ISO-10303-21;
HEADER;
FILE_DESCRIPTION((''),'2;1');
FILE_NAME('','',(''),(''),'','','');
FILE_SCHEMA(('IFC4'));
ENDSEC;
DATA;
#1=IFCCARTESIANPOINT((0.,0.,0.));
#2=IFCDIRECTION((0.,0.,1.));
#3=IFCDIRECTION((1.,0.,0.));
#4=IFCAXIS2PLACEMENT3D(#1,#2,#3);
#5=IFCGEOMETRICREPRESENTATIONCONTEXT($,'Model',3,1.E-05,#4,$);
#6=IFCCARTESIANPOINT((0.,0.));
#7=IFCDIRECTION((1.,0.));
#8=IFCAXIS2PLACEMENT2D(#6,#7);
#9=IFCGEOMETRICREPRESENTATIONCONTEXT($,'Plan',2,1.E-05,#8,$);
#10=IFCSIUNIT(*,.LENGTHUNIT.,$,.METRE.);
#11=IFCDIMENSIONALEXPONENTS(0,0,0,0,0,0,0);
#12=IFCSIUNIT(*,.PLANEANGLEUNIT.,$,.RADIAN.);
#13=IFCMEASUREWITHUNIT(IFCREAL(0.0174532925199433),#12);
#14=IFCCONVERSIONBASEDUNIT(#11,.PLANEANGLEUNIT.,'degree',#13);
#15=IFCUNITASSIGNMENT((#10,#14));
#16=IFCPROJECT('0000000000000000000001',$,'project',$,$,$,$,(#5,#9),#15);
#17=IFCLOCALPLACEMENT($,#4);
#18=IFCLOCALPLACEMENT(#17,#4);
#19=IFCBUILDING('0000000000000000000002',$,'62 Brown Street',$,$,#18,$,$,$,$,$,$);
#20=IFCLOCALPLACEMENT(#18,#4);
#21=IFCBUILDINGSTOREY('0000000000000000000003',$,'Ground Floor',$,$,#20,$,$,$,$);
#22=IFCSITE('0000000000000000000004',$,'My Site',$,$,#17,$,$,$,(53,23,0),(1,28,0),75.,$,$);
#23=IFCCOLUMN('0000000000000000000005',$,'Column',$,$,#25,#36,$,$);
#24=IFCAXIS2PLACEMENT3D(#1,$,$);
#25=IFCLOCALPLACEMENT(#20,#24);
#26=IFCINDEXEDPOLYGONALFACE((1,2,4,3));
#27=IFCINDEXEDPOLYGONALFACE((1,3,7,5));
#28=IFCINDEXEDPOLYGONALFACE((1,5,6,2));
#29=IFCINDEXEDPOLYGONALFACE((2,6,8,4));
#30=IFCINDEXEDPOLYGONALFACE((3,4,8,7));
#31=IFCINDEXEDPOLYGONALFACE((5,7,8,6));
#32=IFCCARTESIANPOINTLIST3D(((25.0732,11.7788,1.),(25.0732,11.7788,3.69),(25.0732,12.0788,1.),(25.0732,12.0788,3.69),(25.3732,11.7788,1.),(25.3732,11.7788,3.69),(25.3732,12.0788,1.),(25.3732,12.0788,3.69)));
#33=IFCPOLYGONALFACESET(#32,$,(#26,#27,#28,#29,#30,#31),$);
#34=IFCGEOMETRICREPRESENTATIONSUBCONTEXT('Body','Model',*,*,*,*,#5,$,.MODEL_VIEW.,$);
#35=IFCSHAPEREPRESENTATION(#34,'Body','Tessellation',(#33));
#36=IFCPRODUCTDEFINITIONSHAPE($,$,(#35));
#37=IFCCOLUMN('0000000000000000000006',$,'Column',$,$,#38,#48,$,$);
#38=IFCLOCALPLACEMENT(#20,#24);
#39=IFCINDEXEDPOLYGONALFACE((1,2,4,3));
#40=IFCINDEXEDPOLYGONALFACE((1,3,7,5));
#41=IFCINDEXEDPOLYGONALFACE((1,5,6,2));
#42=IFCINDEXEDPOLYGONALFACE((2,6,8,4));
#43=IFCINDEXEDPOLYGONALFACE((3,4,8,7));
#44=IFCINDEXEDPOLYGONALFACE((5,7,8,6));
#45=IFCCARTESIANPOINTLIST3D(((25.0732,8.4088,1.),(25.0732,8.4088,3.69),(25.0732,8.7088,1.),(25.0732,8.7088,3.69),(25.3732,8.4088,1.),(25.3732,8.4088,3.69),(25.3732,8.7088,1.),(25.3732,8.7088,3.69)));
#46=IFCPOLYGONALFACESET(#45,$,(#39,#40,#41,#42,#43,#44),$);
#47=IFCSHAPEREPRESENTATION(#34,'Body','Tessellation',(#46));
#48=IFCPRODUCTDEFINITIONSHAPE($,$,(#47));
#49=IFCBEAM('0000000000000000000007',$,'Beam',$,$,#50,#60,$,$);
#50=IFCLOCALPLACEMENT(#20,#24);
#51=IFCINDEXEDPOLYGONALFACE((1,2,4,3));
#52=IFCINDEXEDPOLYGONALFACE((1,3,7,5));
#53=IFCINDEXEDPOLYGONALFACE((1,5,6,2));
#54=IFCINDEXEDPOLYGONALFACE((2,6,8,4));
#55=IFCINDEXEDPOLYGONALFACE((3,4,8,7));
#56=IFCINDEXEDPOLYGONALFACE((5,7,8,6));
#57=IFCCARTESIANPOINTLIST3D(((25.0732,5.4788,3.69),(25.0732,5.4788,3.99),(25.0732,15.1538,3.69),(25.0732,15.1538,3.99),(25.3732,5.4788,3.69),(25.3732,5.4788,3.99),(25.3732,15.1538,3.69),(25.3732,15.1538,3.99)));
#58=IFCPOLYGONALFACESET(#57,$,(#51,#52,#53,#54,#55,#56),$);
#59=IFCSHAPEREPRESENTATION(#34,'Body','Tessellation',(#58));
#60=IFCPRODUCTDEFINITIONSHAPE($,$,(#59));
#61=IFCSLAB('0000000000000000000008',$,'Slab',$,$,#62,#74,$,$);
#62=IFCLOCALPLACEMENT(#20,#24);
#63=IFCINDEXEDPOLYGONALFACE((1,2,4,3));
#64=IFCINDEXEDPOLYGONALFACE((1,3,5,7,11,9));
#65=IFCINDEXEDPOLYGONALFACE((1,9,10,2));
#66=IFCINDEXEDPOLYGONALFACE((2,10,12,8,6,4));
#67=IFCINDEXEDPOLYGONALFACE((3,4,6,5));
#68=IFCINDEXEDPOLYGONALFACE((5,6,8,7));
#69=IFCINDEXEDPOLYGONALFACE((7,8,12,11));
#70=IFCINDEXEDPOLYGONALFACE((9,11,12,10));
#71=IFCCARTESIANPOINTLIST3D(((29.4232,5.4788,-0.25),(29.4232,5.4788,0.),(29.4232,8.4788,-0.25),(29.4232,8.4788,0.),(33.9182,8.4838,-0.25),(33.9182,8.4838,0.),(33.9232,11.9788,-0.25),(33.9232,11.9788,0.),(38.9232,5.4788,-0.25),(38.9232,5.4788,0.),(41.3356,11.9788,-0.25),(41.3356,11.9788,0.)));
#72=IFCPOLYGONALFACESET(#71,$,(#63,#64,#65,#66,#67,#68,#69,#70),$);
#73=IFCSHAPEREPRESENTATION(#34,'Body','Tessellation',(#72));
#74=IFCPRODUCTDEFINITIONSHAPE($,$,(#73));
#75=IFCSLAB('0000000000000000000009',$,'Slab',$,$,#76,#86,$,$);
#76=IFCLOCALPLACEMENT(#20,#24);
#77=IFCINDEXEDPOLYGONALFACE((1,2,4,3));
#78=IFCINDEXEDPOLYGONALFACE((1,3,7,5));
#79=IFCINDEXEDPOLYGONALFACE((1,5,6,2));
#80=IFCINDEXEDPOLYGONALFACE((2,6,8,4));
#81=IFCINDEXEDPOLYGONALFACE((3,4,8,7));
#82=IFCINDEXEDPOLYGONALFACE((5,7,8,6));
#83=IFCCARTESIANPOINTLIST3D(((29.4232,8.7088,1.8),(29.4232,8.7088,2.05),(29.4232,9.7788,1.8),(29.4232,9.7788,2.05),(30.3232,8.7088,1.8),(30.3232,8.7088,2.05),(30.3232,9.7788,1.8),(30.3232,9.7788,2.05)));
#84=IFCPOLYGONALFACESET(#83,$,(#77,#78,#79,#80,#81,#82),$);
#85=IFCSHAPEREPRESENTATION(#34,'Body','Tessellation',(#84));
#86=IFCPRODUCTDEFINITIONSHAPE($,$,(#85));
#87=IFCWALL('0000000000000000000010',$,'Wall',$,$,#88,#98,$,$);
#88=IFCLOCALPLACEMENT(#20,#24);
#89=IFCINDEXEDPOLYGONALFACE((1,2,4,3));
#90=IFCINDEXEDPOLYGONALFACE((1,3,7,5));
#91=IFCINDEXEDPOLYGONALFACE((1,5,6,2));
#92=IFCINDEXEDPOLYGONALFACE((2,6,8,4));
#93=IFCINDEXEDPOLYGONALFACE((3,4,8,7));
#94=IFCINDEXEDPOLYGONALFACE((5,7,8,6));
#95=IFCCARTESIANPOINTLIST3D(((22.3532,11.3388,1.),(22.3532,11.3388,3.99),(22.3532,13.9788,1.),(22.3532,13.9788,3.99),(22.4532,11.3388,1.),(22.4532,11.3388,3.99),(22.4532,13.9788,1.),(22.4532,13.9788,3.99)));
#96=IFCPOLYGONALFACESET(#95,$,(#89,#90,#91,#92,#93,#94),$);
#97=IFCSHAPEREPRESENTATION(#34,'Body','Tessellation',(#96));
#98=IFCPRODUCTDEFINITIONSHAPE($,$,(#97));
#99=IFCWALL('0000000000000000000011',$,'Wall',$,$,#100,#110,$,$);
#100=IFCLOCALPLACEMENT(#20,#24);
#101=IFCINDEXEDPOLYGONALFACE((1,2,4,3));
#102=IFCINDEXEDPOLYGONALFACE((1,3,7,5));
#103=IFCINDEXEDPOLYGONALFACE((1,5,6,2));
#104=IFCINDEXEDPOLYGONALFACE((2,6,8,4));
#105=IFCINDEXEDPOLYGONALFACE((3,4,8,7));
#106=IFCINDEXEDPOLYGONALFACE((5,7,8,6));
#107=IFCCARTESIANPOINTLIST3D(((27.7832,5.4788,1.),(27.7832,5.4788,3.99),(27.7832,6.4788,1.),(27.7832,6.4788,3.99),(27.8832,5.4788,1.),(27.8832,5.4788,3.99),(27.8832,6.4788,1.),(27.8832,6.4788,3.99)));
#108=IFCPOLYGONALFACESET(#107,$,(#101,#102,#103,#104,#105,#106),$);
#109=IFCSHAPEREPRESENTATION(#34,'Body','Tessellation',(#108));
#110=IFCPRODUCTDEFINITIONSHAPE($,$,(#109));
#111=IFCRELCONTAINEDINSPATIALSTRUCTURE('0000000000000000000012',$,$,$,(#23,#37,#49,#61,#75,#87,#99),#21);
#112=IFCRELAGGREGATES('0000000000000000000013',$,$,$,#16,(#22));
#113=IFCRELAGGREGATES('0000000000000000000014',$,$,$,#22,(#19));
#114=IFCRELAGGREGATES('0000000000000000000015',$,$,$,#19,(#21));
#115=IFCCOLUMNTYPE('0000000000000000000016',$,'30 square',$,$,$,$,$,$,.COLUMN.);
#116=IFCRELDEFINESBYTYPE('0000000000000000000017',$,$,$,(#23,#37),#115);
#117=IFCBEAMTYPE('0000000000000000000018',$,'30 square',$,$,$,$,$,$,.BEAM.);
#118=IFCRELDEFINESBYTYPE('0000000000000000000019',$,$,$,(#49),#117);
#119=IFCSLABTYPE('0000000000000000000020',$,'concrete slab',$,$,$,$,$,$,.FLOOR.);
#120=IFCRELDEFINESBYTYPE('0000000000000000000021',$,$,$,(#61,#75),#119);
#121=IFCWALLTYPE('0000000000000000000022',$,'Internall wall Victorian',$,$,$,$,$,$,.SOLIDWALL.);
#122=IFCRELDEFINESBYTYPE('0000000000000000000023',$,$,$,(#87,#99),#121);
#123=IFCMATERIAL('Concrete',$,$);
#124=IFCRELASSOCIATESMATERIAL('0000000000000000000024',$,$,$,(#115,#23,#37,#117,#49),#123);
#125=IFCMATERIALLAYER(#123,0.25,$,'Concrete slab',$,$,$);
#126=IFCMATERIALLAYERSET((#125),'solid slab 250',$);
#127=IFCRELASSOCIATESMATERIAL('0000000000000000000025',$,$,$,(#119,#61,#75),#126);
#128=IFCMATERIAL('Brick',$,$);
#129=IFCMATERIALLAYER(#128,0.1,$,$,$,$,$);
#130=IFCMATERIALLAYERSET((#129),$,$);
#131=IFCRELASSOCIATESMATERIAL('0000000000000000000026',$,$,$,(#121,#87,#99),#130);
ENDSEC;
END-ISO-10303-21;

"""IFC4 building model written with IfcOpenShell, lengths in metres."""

from ifc_helpers import new_model, entity, si_unit, converted_unit, frame, origin_with_axes, origin_2d_with_axis, place, context, subcontext, project, spatial, line, indexed_curve, rectangle, outline, extrude, material, layer, layer_set, layer_usage, material_profile, profile_set, profile_usage, type_object, element, save


model = new_model("IFC4")

# Units and contexts
model_context = context("Model", 3, precision=1e-05, world=origin_with_axes())
plan_context = context("Plan", 2, precision=1e-05, world=origin_2d_with_axis())
body_context_1 = subcontext(model_context, "Body", "Model", "MODEL_VIEW")
ifc_project = project(units=[si_unit("LENGTHUNIT", "METRE"), converted_unit("PLANEANGLEUNIT", "degree", entity("IfcReal", 0.0174532925199433), si_unit("PLANEANGLEUNIT", "RADIAN"), dimensions=[0, 0, 0, 0, 0, 0, 0])], contexts=[model_context, plan_context])

# Site, building, storey
site_placement = place(None, origin_with_axes())
site = spatial("IfcSite", under=ifc_project, at=site_placement, Name="My Site", RefLatitude=(53, 23, 0), RefLongitude=(1, 28, 0), RefElevation=75.0)
building_placement = place(site_placement, origin_with_axes())
building = spatial("IfcBuilding", under=site, at=building_placement, Name="62 Brown Street")
storey_placement = place(building_placement, origin_with_axes())
storey = spatial("IfcBuildingStorey", under=building, at=storey_placement, Name="Ground Floor")

# Columns
ifc_material_1 = material(Name="Concrete")
ifc_material_profile_1 = material_profile(ifc_material_1, rectangle(XDim=0.3, YDim=0.3))
ifc_profile_set_1 = profile_set([ifc_material_profile_1])
ifc_profile_usage_1 = profile_usage(ifc_profile_set_1, cardinal=5)
column_type = type_object("IfcColumnType", Name="30 square", PredefinedType="COLUMN", material=ifc_profile_set_1)
column_1_placement = place(storey_placement, frame((25.2232, 11.9288, 1.0), z_axis=(0.0, 0.0, 1.0), x_axis=(1.0, 0.0, 0.0)))
element("IfcColumn", 1, at=column_1_placement, inside=storey, type_object=column_type, material=ifc_profile_usage_1, Name="Column", context=body_context_1, shape_type="SweptSolid", body=[
    extrude(rectangle(XDim=0.3, YDim=0.3), origin_with_axes(), (0.0, 0.0, 1.0), 2.69),
])
ifc_profile_usage_2 = profile_usage(ifc_profile_set_1, cardinal=5)
column_2_placement = place(storey_placement, frame((25.2232, 8.5588, 1.0), z_axis=(0.0, 0.0, 1.0), x_axis=(1.0, 0.0, 0.0)))
element("IfcColumn", 2, at=column_2_placement, inside=storey, type_object=column_type, material=ifc_profile_usage_2, Name="Column", context=body_context_1, shape_type="SweptSolid", body=[
    extrude(rectangle(XDim=0.3, YDim=0.3), origin_with_axes(), (0.0, 0.0, 1.0), 2.69),
])

# Beam
ifc_material_profile_2 = material_profile(ifc_material_1, rectangle(XDim=0.3, YDim=0.3))
ifc_profile_set_2 = profile_set([ifc_material_profile_2])
ifc_profile_usage_3 = profile_usage(ifc_profile_set_2, cardinal=5)
beam_type = type_object("IfcBeamType", Name="30 square", PredefinedType="BEAM", material=ifc_profile_set_2)
beam_placement = place(storey_placement, frame((25.2232, 5.4788, 3.84), z_axis=(0.0, 1.0, 0.0), x_axis=(-1.0, 0.0, 0.0)))
element("IfcBeam", 3, at=beam_placement, inside=storey, type_object=beam_type, material=ifc_profile_usage_3, Name="Beam", context=body_context_1, shape_type="SweptSolid", body=[
    extrude(rectangle(XDim=0.3, YDim=0.3), origin_with_axes(), (0.0, 0.0, 1.0), 9.675),
])

# Slabs
ifc_layer_1 = layer(ifc_material_1, 0.25, Name="Concrete slab")
ifc_layer_set_1 = layer_set([ifc_layer_1], Name="solid slab 250")
ifc_layer_usage_1 = layer_usage(ifc_layer_set_1, "AXIS3", "POSITIVE", 0.0)
slab_type = type_object("IfcSlabType", Name="concrete slab", PredefinedType="FLOOR", material=ifc_layer_set_1)
slab_1_placement = place(storey_placement, frame((29.4232, 5.4788, -0.25), z_axis=(0.0, 0.0, 1.0), x_axis=(1.0, 0.0, 0.0)))
element("IfcSlab", 4, at=slab_1_placement, inside=storey, type_object=slab_type, material=ifc_layer_usage_1, Name="Slab", context=body_context_1, shape_type="SweptSolid", body=[
    extrude(outline(indexed_curve([(0.0, 0.0), (9.5, 0.0), (11.9124, 6.5), (0.0, 3.0), (4.5, 6.5), (4.495, 3.005)], segments=[line(1, 2), line(2, 3), line(3, 5), line(5, 6), line(6, 4), line(4, 1)], self_intersect=False)), None, (0.0, 0.0, 1.0), 0.25),
])
ifc_layer_usage_2 = layer_usage(ifc_layer_set_1, "AXIS3", "POSITIVE", 0.0)
slab_2_placement = place(storey_placement, frame((29.4232, 8.7088, 1.8), z_axis=(0.0, 0.0, 1.0), x_axis=(1.0, 0.0, 0.0)))
element("IfcSlab", 5, at=slab_2_placement, inside=storey, type_object=slab_type, material=ifc_layer_usage_2, Name="Slab", context=body_context_1, shape_type="SweptSolid", body=[
    extrude(outline(indexed_curve([(0.9, 1.07), (0.9, 0.0), (0.0, 0.0), (0.0, 1.07)], segments=[line(3, 2), line(2, 1), line(1, 4), line(4, 3)], self_intersect=False)), None, (0.0, 0.0, 1.0), 0.25),
])

# Walls
ifc_material_2 = material(Name="Brick")
ifc_layer_2 = layer(ifc_material_2, 0.1)
ifc_layer_set_2 = layer_set([ifc_layer_2])
ifc_layer_usage_3 = layer_usage(ifc_layer_set_2, "AXIS2", "POSITIVE", 0.0)
wall_type_1 = type_object("IfcWallType", Name="Internall wall Victorian", PredefinedType="SOLIDWALL", material=ifc_layer_set_2)
wall_1_placement = place(storey_placement, frame((22.4532, 11.3388, 1.0), z_axis=(0.0, 0.0, 1.0), x_axis=(0.0, 1.0, 0.0)))
element("IfcWall", 6, at=wall_1_placement, inside=storey, type_object=wall_type_1, material=ifc_layer_usage_3, Name="Wall", context=body_context_1, shape_type="SweptSolid", body=[
    extrude(outline(indexed_curve([(0.0, 0.0), (0.0, 0.1), (2.64, 0.1), (2.64, 0.0), (0.0, 0.0)], self_intersect=False)), origin_with_axes(), (0.0, 0.0, 1.0), 2.99),
])
ifc_layer_usage_4 = layer_usage(ifc_layer_set_2, "AXIS2", "POSITIVE", 0.0)
wall_2_placement = place(storey_placement, frame((27.8832, 5.4788, 1.0), z_axis=(0.0, 0.0, 1.0), x_axis=(0.0, 1.0, 0.0)))
element("IfcWall", 7, at=wall_2_placement, inside=storey, type_object=wall_type_1, material=ifc_layer_usage_4, Name="Wall", context=body_context_1, shape_type="SweptSolid", body=[
    extrude(outline(indexed_curve([(0.0, 0.0), (0.0, 0.1), (1.0, 0.1), (1.0, 0.0), (0.0, 0.0)], self_intersect=False)), origin_with_axes(), (0.0, 0.0, 1.0), 2.99),
])

save(model, "model.ifc")
